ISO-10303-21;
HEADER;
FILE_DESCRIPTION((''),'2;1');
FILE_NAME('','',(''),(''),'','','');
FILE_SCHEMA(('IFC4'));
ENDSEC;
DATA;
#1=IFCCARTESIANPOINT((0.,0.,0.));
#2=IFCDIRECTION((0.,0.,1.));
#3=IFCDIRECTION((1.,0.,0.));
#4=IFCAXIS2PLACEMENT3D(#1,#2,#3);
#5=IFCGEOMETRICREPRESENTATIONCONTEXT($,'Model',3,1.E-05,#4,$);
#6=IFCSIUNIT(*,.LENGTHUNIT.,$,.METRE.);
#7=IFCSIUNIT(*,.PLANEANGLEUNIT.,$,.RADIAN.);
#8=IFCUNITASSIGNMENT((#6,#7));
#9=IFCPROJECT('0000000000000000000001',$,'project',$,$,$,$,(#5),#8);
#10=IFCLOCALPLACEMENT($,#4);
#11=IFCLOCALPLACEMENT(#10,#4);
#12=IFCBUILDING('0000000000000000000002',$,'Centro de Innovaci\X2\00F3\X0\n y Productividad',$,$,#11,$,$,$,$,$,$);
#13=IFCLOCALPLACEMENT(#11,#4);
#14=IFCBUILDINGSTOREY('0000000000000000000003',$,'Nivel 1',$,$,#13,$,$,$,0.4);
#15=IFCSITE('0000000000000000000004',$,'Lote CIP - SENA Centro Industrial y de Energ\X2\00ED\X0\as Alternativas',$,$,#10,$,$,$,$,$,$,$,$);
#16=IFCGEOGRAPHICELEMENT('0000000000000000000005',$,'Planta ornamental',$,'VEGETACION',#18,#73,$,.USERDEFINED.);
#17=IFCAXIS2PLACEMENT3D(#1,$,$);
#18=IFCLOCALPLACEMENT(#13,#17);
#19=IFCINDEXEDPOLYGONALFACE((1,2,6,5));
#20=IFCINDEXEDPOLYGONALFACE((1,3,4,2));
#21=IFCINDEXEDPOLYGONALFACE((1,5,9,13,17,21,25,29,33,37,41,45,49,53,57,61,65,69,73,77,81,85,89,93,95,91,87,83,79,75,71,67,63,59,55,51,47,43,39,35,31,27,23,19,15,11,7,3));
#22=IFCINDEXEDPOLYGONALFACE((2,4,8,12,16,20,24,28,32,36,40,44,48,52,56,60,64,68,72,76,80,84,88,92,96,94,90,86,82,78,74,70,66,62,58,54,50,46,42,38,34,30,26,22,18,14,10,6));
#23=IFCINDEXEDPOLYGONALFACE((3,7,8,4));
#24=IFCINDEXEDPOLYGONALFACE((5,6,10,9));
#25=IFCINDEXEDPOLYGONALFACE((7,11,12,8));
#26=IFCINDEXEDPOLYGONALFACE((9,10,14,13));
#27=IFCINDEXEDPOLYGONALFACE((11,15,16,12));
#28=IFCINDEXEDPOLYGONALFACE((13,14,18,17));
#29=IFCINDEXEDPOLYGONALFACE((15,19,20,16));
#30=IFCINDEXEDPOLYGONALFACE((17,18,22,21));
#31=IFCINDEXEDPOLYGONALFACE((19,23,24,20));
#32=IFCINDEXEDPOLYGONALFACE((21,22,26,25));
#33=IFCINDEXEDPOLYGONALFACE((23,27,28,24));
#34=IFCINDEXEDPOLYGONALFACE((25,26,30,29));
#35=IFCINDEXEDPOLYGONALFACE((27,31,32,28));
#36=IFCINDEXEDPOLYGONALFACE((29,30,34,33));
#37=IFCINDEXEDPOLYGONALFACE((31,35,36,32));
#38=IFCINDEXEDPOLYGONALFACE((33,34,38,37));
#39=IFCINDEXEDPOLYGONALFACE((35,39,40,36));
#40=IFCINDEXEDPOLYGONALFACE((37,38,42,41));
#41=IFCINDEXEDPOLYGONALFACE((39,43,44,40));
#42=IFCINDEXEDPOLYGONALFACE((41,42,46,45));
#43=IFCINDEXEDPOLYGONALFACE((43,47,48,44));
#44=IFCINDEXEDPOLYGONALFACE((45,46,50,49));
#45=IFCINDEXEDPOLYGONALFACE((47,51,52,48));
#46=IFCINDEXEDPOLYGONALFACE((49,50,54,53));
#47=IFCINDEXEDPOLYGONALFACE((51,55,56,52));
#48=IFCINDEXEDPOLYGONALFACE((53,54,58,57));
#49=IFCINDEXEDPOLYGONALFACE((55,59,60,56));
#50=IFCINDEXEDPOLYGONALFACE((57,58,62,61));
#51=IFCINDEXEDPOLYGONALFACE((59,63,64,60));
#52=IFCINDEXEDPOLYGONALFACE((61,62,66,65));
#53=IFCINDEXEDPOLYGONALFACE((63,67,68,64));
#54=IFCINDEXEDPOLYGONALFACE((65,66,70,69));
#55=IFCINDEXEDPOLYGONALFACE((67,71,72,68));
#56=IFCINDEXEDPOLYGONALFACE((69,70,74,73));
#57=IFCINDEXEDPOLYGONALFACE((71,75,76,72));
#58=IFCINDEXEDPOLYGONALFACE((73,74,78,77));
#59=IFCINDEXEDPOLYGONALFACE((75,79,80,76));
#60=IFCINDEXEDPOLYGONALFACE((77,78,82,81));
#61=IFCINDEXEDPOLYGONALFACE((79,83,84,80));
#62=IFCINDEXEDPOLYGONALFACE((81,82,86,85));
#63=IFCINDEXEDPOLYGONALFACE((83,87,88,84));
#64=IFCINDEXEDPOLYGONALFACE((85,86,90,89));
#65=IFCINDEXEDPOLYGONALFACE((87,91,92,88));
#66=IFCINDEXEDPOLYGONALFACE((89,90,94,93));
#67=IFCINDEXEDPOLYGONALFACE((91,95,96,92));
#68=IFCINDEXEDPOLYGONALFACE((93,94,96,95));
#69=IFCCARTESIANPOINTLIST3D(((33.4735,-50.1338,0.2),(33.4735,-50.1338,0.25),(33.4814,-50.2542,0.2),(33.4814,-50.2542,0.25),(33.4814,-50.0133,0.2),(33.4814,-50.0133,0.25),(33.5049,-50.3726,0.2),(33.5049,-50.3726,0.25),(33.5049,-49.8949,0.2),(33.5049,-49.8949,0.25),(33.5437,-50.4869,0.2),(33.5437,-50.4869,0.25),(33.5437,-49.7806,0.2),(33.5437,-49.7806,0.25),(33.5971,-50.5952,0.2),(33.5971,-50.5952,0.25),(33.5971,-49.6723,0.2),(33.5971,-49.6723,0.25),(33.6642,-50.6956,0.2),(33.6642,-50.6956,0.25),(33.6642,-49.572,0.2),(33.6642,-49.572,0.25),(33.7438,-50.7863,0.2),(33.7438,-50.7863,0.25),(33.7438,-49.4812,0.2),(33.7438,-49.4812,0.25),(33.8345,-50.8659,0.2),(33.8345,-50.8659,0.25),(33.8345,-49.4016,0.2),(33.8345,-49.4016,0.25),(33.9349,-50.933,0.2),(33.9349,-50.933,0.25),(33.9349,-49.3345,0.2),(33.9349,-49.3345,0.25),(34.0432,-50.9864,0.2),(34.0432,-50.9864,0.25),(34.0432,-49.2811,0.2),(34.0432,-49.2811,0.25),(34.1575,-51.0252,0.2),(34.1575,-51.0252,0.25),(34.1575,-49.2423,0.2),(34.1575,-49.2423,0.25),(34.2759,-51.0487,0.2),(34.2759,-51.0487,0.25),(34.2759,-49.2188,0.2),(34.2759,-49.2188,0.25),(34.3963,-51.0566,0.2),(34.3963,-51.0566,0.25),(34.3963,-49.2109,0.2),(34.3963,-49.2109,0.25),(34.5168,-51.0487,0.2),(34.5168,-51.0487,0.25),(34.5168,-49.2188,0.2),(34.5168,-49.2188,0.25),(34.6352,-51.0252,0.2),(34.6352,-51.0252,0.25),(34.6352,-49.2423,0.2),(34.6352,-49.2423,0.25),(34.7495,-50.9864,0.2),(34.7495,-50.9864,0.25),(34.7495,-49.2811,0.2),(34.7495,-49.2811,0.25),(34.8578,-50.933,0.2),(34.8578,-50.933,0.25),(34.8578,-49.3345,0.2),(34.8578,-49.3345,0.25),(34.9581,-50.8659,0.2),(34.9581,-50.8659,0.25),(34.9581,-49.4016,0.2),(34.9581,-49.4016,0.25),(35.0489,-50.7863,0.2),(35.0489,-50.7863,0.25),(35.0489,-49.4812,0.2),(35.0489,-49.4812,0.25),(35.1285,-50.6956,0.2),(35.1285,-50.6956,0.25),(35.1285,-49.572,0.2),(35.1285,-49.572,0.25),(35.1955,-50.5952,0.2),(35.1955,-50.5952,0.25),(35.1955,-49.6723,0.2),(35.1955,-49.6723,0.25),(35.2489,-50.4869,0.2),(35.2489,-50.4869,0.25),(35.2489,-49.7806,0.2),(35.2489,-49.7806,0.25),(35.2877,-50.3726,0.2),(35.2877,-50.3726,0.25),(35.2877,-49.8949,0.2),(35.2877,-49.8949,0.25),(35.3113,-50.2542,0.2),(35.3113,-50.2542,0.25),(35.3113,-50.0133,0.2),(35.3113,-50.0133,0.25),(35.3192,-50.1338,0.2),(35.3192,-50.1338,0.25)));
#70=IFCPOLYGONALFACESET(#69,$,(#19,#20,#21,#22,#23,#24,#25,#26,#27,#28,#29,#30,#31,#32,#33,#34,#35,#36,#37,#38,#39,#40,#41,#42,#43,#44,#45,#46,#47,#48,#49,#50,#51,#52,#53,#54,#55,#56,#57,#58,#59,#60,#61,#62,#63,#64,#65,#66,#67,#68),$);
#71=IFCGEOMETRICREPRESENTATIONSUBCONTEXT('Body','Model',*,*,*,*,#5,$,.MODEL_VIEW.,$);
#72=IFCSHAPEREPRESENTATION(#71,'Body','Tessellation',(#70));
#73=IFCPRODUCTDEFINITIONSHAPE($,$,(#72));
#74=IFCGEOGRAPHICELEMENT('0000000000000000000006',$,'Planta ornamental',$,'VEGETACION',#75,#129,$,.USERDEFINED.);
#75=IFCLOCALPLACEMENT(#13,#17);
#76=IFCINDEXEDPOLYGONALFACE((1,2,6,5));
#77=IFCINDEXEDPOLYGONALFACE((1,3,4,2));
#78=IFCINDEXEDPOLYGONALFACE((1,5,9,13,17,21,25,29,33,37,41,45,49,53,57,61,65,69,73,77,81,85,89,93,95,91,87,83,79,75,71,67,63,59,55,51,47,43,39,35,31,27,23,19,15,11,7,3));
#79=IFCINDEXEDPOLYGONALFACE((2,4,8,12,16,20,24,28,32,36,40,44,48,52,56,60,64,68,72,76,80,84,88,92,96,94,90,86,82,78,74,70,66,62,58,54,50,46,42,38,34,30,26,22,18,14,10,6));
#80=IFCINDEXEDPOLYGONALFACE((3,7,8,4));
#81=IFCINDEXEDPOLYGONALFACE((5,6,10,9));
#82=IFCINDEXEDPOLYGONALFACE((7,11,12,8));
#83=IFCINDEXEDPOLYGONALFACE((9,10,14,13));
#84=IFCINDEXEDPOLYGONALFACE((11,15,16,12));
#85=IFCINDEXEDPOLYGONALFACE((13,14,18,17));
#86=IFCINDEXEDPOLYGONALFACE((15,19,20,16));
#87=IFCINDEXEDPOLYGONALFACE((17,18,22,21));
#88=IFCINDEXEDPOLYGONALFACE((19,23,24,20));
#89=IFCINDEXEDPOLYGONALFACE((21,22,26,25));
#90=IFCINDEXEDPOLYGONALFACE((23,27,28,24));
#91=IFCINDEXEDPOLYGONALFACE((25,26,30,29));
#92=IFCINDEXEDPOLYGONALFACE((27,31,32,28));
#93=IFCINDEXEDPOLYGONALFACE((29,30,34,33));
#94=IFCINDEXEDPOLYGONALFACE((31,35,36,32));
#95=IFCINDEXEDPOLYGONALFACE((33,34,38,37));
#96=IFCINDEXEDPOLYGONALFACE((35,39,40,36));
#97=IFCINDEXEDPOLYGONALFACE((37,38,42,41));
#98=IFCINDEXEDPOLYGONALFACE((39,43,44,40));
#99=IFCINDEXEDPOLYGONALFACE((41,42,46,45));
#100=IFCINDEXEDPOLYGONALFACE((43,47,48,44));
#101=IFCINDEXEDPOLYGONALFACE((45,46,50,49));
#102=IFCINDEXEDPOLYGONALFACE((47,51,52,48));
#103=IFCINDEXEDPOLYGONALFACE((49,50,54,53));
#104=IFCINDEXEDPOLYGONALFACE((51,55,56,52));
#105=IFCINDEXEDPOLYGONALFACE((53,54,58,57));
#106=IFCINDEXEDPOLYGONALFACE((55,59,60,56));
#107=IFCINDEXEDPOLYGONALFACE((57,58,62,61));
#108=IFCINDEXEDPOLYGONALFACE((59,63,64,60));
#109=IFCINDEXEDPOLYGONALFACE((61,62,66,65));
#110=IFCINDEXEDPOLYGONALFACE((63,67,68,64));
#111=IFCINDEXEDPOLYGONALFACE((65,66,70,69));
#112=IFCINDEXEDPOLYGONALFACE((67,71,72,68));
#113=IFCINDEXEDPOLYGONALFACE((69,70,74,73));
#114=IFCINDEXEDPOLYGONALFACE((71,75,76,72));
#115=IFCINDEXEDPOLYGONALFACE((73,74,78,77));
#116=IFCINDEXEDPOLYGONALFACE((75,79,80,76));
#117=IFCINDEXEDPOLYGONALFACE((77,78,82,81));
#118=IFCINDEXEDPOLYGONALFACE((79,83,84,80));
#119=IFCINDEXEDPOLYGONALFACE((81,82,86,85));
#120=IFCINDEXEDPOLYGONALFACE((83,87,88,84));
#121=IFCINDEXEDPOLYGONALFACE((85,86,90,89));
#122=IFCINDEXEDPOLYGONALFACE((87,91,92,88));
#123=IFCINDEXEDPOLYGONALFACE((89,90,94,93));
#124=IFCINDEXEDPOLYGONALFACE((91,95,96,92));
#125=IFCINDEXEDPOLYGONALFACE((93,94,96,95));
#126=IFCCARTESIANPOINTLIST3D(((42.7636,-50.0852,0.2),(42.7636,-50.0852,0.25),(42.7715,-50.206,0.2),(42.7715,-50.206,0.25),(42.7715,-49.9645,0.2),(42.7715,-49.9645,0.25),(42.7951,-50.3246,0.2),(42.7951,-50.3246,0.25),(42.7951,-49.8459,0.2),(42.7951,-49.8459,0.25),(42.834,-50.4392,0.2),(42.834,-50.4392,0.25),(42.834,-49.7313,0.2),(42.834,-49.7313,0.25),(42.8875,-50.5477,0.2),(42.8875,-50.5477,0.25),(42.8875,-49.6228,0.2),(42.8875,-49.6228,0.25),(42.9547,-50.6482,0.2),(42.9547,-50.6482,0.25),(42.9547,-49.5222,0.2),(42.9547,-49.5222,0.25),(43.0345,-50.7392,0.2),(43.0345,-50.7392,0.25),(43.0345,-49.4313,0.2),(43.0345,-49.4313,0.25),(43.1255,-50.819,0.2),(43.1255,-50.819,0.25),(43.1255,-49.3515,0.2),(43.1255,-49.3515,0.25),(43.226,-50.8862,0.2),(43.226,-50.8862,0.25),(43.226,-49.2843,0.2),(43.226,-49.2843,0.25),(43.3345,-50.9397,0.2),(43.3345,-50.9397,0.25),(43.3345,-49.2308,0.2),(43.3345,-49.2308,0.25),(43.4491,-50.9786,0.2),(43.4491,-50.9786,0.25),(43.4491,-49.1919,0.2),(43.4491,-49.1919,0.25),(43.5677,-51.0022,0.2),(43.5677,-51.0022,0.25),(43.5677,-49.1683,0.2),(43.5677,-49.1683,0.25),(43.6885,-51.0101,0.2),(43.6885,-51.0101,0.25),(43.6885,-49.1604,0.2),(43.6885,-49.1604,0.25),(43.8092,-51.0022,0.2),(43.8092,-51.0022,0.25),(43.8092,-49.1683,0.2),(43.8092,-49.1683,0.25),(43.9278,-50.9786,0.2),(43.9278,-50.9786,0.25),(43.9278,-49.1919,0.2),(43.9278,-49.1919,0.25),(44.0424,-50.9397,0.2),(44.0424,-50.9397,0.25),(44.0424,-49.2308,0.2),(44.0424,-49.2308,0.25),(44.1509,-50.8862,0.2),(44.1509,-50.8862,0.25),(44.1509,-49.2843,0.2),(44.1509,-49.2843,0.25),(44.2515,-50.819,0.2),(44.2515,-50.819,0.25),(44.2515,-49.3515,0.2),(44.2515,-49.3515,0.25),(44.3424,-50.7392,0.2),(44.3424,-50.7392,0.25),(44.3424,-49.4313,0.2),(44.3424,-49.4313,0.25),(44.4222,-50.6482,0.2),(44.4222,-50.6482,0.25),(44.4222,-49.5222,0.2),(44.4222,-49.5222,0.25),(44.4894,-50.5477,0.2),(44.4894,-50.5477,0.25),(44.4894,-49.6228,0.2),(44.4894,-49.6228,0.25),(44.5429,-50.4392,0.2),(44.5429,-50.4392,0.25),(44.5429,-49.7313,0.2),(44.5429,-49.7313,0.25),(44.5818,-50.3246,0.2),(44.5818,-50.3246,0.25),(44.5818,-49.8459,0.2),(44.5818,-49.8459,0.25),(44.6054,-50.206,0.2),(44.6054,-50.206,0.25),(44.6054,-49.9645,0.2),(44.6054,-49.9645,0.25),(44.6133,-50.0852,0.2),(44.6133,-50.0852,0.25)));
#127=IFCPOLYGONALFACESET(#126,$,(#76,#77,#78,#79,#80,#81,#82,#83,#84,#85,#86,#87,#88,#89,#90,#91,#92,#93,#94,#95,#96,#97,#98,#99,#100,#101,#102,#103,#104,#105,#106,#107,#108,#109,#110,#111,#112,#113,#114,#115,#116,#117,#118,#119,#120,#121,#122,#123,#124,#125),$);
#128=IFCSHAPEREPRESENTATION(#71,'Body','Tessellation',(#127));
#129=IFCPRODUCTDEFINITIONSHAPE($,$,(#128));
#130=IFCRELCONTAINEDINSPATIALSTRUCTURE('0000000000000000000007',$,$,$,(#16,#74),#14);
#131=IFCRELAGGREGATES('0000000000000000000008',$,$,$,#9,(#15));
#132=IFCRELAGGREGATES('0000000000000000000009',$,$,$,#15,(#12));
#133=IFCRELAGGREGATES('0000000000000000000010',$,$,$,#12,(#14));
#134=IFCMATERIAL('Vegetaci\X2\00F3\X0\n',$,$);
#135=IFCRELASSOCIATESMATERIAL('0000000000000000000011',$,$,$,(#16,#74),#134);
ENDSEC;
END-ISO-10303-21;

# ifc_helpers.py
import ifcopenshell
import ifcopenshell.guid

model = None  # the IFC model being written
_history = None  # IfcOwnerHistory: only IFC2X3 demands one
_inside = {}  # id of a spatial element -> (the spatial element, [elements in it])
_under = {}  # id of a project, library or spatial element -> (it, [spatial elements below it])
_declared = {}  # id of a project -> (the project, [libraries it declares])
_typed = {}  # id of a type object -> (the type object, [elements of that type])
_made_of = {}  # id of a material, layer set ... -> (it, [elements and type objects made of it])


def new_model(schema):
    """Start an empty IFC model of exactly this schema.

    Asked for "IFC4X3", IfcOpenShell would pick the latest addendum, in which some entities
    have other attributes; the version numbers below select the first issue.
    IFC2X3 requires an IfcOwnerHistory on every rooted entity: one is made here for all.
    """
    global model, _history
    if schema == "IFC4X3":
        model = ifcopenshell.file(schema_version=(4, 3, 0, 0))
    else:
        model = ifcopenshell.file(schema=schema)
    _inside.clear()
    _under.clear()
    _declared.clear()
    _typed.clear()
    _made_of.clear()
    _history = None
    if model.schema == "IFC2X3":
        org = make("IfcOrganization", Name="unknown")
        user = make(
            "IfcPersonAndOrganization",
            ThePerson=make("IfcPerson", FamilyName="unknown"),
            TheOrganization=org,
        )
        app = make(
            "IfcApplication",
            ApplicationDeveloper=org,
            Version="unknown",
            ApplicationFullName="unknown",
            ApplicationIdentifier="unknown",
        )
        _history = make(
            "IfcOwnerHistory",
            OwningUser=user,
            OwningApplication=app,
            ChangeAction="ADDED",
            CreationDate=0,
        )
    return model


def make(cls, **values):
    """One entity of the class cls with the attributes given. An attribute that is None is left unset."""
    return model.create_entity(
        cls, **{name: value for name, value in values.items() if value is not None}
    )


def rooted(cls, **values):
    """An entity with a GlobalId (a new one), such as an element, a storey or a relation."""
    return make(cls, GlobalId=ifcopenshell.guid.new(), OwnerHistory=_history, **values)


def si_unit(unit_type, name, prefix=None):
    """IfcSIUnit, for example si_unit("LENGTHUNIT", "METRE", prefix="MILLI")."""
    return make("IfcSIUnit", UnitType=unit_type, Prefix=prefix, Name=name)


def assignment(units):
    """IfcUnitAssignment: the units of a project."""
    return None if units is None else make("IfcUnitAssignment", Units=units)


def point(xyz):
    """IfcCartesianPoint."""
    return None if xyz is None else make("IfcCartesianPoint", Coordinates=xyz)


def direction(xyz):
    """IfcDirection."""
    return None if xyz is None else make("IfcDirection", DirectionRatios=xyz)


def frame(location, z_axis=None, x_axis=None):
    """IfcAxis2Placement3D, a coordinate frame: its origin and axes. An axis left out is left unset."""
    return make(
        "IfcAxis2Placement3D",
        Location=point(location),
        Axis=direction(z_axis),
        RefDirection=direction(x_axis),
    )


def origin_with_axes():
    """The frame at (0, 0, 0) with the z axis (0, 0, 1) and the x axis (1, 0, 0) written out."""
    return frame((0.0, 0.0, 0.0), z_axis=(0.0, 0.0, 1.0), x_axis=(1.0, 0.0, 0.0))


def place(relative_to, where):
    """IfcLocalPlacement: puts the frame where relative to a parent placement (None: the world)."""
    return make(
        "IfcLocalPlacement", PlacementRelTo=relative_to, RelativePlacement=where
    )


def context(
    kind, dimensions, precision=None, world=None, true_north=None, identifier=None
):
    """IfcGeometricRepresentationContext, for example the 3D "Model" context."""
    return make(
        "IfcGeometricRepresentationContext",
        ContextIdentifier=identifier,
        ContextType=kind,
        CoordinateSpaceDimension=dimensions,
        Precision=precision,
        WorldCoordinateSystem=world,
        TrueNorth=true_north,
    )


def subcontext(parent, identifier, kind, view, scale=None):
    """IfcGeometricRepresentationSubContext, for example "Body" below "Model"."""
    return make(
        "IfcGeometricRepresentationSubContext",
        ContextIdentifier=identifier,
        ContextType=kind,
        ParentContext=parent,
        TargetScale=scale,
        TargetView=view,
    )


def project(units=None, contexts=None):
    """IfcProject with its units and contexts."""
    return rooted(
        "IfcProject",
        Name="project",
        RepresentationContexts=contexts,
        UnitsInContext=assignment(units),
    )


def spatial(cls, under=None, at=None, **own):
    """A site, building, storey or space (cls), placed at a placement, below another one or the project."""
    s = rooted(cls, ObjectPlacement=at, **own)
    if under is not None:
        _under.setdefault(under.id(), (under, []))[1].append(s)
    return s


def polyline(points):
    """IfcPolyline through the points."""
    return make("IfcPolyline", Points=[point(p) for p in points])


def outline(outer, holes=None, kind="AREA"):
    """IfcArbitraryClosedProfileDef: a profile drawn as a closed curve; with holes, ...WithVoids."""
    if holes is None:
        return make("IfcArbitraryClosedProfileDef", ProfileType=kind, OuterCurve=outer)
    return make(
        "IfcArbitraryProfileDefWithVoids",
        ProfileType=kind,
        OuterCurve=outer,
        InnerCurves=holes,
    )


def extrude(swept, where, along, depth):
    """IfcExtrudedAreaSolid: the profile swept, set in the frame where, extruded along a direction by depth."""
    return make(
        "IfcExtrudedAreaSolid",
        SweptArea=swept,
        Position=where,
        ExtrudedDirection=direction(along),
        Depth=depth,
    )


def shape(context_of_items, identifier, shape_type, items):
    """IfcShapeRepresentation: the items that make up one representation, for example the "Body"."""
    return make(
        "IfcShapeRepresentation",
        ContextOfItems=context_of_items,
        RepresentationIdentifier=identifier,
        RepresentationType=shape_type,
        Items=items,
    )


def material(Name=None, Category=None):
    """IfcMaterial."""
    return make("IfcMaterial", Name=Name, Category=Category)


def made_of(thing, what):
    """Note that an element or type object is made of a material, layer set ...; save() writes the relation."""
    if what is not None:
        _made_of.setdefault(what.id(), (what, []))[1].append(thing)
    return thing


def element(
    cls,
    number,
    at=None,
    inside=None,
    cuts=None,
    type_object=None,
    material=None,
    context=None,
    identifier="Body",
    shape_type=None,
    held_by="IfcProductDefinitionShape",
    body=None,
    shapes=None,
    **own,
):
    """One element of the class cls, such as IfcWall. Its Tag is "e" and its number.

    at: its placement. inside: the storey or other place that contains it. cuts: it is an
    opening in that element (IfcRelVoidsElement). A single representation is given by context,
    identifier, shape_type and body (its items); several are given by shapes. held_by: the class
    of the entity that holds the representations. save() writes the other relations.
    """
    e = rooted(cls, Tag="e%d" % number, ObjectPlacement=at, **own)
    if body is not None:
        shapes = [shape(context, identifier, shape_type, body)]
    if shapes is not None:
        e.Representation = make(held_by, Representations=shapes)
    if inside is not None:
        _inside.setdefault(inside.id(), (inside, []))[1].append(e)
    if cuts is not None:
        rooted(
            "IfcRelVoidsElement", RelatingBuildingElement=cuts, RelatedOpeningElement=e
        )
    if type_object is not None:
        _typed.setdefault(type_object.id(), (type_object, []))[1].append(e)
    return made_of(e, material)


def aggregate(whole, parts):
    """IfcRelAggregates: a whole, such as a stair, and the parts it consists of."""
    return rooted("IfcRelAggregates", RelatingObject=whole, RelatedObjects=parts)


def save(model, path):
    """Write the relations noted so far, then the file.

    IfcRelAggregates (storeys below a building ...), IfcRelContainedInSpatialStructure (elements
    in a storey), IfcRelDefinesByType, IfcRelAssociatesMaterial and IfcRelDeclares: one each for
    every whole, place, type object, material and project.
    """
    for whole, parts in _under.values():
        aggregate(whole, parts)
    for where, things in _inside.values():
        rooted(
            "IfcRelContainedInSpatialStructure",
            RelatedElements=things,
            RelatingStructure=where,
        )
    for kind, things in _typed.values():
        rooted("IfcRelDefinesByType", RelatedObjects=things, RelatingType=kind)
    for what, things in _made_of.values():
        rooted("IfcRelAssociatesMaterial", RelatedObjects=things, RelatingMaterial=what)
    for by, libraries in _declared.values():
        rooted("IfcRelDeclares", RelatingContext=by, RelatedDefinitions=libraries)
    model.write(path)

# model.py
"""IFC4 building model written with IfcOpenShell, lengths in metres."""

from ifc_helpers import new_model, si_unit, frame, origin_with_axes, place, context, subcontext, project, spatial, polyline, outline, extrude, material, element, save


model = new_model("IFC4")

# Units and contexts
model_context = context("Model", 3, precision=1e-05, world=origin_with_axes())
body_context = subcontext(model_context, "Body", "Model", "MODEL_VIEW")
ifc_project = project(units=[si_unit("LENGTHUNIT", "METRE"), si_unit("PLANEANGLEUNIT", "RADIAN")], contexts=[model_context])

# Site, building, storey
site_placement = place(None, origin_with_axes())
site = spatial("IfcSite", under=ifc_project, at=site_placement, Name="Lote CIP - SENA Centro Industrial y de Energías Alternativas")
building_placement = place(site_placement, origin_with_axes())
building = spatial("IfcBuilding", under=site, at=building_placement, Name="Centro de Innovación y Productividad")
storey_placement = place(building_placement, origin_with_axes())
storey = spatial("IfcBuildingStorey", under=building, at=storey_placement, Name="Nivel 1", Elevation=0.4)

# Geographic elements
ifc_material = material(Name="Vegetación")
geographic_element_1_placement = place(storey_placement, origin_with_axes())
element("IfcGeographicElement", 1, at=geographic_element_1_placement, inside=storey, material=ifc_material, Name="Planta ornamental", ObjectType="VEGETACION", PredefinedType="USERDEFINED", context=body_context, shape_type="SweptSolid", body=[
    extrude(outline(polyline([(35.3192, -50.1338), (35.3113, -50.2542), (35.2877, -50.3726), (35.2489, -50.4869), (35.1955, -50.5952), (35.1285, -50.6956), (35.0489, -50.7863), (34.9581, -50.8659), (34.8578, -50.933), (34.7495, -50.9864), (34.6352, -51.0252), (34.5168, -51.0487), (34.3963, -51.0566), (34.2759, -51.0487), (34.1575, -51.0252), (34.0432, -50.9864), (33.9349, -50.933), (33.8345, -50.8659), (33.7438, -50.7863), (33.6642, -50.6956), (33.5971, -50.5952), (33.5437, -50.4869), (33.5049, -50.3726), (33.4814, -50.2542), (33.4735, -50.1338), (33.4814, -50.0133), (33.5049, -49.8949), (33.5437, -49.7806), (33.5971, -49.6723), (33.6642, -49.572), (33.7438, -49.4812), (33.8345, -49.4016), (33.9349, -49.3345), (34.0432, -49.2811), (34.1575, -49.2423), (34.2759, -49.2188), (34.3963, -49.2109), (34.5168, -49.2188), (34.6352, -49.2423), (34.7495, -49.2811), (34.8578, -49.3345), (34.9581, -49.4016), (35.0489, -49.4812), (35.1285, -49.572), (35.1955, -49.6723), (35.2489, -49.7806), (35.2877, -49.8949), (35.3113, -50.0133), (35.3192, -50.1338)])), frame((0.0, 0.0, 0.2)), (0.0, 0.0, 1.0), 0.05),
])
geographic_element_2_placement = place(storey_placement, origin_with_axes())
element("IfcGeographicElement", 2, at=geographic_element_2_placement, inside=storey, material=ifc_material, Name="Planta ornamental", ObjectType="VEGETACION", PredefinedType="USERDEFINED", context=body_context, shape_type="SweptSolid", body=[
    extrude(outline(polyline([(44.6133, -50.0852), (44.6054, -50.206), (44.5818, -50.3246), (44.5429, -50.4392), (44.4894, -50.5477), (44.4222, -50.6482), (44.3424, -50.7392), (44.2515, -50.819), (44.1509, -50.8862), (44.0424, -50.9397), (43.9278, -50.9786), (43.8092, -51.0022), (43.6885, -51.0101), (43.5677, -51.0022), (43.4491, -50.9786), (43.3345, -50.9397), (43.226, -50.8862), (43.1255, -50.819), (43.0345, -50.7392), (42.9547, -50.6482), (42.8875, -50.5477), (42.834, -50.4392), (42.7951, -50.3246), (42.7715, -50.206), (42.7636, -50.0852), (42.7715, -49.9645), (42.7951, -49.8459), (42.834, -49.7313), (42.8875, -49.6228), (42.9547, -49.5222), (43.0345, -49.4313), (43.1255, -49.3515), (43.226, -49.2843), (43.3345, -49.2308), (43.4491, -49.1919), (43.5677, -49.1683), (43.6885, -49.1604), (43.8092, -49.1683), (43.9278, -49.1919), (44.0424, -49.2308), (44.1509, -49.2843), (44.2515, -49.3515), (44.3424, -49.4313), (44.4222, -49.5222), (44.4894, -49.6228), (44.5429, -49.7313), (44.5818, -49.8459), (44.6054, -49.9645), (44.6133, -50.0852)])), frame((0.0, 0.0, 0.2)), (0.0, 0.0, 1.0), 0.05),
])

save(model, "model.ifc")
